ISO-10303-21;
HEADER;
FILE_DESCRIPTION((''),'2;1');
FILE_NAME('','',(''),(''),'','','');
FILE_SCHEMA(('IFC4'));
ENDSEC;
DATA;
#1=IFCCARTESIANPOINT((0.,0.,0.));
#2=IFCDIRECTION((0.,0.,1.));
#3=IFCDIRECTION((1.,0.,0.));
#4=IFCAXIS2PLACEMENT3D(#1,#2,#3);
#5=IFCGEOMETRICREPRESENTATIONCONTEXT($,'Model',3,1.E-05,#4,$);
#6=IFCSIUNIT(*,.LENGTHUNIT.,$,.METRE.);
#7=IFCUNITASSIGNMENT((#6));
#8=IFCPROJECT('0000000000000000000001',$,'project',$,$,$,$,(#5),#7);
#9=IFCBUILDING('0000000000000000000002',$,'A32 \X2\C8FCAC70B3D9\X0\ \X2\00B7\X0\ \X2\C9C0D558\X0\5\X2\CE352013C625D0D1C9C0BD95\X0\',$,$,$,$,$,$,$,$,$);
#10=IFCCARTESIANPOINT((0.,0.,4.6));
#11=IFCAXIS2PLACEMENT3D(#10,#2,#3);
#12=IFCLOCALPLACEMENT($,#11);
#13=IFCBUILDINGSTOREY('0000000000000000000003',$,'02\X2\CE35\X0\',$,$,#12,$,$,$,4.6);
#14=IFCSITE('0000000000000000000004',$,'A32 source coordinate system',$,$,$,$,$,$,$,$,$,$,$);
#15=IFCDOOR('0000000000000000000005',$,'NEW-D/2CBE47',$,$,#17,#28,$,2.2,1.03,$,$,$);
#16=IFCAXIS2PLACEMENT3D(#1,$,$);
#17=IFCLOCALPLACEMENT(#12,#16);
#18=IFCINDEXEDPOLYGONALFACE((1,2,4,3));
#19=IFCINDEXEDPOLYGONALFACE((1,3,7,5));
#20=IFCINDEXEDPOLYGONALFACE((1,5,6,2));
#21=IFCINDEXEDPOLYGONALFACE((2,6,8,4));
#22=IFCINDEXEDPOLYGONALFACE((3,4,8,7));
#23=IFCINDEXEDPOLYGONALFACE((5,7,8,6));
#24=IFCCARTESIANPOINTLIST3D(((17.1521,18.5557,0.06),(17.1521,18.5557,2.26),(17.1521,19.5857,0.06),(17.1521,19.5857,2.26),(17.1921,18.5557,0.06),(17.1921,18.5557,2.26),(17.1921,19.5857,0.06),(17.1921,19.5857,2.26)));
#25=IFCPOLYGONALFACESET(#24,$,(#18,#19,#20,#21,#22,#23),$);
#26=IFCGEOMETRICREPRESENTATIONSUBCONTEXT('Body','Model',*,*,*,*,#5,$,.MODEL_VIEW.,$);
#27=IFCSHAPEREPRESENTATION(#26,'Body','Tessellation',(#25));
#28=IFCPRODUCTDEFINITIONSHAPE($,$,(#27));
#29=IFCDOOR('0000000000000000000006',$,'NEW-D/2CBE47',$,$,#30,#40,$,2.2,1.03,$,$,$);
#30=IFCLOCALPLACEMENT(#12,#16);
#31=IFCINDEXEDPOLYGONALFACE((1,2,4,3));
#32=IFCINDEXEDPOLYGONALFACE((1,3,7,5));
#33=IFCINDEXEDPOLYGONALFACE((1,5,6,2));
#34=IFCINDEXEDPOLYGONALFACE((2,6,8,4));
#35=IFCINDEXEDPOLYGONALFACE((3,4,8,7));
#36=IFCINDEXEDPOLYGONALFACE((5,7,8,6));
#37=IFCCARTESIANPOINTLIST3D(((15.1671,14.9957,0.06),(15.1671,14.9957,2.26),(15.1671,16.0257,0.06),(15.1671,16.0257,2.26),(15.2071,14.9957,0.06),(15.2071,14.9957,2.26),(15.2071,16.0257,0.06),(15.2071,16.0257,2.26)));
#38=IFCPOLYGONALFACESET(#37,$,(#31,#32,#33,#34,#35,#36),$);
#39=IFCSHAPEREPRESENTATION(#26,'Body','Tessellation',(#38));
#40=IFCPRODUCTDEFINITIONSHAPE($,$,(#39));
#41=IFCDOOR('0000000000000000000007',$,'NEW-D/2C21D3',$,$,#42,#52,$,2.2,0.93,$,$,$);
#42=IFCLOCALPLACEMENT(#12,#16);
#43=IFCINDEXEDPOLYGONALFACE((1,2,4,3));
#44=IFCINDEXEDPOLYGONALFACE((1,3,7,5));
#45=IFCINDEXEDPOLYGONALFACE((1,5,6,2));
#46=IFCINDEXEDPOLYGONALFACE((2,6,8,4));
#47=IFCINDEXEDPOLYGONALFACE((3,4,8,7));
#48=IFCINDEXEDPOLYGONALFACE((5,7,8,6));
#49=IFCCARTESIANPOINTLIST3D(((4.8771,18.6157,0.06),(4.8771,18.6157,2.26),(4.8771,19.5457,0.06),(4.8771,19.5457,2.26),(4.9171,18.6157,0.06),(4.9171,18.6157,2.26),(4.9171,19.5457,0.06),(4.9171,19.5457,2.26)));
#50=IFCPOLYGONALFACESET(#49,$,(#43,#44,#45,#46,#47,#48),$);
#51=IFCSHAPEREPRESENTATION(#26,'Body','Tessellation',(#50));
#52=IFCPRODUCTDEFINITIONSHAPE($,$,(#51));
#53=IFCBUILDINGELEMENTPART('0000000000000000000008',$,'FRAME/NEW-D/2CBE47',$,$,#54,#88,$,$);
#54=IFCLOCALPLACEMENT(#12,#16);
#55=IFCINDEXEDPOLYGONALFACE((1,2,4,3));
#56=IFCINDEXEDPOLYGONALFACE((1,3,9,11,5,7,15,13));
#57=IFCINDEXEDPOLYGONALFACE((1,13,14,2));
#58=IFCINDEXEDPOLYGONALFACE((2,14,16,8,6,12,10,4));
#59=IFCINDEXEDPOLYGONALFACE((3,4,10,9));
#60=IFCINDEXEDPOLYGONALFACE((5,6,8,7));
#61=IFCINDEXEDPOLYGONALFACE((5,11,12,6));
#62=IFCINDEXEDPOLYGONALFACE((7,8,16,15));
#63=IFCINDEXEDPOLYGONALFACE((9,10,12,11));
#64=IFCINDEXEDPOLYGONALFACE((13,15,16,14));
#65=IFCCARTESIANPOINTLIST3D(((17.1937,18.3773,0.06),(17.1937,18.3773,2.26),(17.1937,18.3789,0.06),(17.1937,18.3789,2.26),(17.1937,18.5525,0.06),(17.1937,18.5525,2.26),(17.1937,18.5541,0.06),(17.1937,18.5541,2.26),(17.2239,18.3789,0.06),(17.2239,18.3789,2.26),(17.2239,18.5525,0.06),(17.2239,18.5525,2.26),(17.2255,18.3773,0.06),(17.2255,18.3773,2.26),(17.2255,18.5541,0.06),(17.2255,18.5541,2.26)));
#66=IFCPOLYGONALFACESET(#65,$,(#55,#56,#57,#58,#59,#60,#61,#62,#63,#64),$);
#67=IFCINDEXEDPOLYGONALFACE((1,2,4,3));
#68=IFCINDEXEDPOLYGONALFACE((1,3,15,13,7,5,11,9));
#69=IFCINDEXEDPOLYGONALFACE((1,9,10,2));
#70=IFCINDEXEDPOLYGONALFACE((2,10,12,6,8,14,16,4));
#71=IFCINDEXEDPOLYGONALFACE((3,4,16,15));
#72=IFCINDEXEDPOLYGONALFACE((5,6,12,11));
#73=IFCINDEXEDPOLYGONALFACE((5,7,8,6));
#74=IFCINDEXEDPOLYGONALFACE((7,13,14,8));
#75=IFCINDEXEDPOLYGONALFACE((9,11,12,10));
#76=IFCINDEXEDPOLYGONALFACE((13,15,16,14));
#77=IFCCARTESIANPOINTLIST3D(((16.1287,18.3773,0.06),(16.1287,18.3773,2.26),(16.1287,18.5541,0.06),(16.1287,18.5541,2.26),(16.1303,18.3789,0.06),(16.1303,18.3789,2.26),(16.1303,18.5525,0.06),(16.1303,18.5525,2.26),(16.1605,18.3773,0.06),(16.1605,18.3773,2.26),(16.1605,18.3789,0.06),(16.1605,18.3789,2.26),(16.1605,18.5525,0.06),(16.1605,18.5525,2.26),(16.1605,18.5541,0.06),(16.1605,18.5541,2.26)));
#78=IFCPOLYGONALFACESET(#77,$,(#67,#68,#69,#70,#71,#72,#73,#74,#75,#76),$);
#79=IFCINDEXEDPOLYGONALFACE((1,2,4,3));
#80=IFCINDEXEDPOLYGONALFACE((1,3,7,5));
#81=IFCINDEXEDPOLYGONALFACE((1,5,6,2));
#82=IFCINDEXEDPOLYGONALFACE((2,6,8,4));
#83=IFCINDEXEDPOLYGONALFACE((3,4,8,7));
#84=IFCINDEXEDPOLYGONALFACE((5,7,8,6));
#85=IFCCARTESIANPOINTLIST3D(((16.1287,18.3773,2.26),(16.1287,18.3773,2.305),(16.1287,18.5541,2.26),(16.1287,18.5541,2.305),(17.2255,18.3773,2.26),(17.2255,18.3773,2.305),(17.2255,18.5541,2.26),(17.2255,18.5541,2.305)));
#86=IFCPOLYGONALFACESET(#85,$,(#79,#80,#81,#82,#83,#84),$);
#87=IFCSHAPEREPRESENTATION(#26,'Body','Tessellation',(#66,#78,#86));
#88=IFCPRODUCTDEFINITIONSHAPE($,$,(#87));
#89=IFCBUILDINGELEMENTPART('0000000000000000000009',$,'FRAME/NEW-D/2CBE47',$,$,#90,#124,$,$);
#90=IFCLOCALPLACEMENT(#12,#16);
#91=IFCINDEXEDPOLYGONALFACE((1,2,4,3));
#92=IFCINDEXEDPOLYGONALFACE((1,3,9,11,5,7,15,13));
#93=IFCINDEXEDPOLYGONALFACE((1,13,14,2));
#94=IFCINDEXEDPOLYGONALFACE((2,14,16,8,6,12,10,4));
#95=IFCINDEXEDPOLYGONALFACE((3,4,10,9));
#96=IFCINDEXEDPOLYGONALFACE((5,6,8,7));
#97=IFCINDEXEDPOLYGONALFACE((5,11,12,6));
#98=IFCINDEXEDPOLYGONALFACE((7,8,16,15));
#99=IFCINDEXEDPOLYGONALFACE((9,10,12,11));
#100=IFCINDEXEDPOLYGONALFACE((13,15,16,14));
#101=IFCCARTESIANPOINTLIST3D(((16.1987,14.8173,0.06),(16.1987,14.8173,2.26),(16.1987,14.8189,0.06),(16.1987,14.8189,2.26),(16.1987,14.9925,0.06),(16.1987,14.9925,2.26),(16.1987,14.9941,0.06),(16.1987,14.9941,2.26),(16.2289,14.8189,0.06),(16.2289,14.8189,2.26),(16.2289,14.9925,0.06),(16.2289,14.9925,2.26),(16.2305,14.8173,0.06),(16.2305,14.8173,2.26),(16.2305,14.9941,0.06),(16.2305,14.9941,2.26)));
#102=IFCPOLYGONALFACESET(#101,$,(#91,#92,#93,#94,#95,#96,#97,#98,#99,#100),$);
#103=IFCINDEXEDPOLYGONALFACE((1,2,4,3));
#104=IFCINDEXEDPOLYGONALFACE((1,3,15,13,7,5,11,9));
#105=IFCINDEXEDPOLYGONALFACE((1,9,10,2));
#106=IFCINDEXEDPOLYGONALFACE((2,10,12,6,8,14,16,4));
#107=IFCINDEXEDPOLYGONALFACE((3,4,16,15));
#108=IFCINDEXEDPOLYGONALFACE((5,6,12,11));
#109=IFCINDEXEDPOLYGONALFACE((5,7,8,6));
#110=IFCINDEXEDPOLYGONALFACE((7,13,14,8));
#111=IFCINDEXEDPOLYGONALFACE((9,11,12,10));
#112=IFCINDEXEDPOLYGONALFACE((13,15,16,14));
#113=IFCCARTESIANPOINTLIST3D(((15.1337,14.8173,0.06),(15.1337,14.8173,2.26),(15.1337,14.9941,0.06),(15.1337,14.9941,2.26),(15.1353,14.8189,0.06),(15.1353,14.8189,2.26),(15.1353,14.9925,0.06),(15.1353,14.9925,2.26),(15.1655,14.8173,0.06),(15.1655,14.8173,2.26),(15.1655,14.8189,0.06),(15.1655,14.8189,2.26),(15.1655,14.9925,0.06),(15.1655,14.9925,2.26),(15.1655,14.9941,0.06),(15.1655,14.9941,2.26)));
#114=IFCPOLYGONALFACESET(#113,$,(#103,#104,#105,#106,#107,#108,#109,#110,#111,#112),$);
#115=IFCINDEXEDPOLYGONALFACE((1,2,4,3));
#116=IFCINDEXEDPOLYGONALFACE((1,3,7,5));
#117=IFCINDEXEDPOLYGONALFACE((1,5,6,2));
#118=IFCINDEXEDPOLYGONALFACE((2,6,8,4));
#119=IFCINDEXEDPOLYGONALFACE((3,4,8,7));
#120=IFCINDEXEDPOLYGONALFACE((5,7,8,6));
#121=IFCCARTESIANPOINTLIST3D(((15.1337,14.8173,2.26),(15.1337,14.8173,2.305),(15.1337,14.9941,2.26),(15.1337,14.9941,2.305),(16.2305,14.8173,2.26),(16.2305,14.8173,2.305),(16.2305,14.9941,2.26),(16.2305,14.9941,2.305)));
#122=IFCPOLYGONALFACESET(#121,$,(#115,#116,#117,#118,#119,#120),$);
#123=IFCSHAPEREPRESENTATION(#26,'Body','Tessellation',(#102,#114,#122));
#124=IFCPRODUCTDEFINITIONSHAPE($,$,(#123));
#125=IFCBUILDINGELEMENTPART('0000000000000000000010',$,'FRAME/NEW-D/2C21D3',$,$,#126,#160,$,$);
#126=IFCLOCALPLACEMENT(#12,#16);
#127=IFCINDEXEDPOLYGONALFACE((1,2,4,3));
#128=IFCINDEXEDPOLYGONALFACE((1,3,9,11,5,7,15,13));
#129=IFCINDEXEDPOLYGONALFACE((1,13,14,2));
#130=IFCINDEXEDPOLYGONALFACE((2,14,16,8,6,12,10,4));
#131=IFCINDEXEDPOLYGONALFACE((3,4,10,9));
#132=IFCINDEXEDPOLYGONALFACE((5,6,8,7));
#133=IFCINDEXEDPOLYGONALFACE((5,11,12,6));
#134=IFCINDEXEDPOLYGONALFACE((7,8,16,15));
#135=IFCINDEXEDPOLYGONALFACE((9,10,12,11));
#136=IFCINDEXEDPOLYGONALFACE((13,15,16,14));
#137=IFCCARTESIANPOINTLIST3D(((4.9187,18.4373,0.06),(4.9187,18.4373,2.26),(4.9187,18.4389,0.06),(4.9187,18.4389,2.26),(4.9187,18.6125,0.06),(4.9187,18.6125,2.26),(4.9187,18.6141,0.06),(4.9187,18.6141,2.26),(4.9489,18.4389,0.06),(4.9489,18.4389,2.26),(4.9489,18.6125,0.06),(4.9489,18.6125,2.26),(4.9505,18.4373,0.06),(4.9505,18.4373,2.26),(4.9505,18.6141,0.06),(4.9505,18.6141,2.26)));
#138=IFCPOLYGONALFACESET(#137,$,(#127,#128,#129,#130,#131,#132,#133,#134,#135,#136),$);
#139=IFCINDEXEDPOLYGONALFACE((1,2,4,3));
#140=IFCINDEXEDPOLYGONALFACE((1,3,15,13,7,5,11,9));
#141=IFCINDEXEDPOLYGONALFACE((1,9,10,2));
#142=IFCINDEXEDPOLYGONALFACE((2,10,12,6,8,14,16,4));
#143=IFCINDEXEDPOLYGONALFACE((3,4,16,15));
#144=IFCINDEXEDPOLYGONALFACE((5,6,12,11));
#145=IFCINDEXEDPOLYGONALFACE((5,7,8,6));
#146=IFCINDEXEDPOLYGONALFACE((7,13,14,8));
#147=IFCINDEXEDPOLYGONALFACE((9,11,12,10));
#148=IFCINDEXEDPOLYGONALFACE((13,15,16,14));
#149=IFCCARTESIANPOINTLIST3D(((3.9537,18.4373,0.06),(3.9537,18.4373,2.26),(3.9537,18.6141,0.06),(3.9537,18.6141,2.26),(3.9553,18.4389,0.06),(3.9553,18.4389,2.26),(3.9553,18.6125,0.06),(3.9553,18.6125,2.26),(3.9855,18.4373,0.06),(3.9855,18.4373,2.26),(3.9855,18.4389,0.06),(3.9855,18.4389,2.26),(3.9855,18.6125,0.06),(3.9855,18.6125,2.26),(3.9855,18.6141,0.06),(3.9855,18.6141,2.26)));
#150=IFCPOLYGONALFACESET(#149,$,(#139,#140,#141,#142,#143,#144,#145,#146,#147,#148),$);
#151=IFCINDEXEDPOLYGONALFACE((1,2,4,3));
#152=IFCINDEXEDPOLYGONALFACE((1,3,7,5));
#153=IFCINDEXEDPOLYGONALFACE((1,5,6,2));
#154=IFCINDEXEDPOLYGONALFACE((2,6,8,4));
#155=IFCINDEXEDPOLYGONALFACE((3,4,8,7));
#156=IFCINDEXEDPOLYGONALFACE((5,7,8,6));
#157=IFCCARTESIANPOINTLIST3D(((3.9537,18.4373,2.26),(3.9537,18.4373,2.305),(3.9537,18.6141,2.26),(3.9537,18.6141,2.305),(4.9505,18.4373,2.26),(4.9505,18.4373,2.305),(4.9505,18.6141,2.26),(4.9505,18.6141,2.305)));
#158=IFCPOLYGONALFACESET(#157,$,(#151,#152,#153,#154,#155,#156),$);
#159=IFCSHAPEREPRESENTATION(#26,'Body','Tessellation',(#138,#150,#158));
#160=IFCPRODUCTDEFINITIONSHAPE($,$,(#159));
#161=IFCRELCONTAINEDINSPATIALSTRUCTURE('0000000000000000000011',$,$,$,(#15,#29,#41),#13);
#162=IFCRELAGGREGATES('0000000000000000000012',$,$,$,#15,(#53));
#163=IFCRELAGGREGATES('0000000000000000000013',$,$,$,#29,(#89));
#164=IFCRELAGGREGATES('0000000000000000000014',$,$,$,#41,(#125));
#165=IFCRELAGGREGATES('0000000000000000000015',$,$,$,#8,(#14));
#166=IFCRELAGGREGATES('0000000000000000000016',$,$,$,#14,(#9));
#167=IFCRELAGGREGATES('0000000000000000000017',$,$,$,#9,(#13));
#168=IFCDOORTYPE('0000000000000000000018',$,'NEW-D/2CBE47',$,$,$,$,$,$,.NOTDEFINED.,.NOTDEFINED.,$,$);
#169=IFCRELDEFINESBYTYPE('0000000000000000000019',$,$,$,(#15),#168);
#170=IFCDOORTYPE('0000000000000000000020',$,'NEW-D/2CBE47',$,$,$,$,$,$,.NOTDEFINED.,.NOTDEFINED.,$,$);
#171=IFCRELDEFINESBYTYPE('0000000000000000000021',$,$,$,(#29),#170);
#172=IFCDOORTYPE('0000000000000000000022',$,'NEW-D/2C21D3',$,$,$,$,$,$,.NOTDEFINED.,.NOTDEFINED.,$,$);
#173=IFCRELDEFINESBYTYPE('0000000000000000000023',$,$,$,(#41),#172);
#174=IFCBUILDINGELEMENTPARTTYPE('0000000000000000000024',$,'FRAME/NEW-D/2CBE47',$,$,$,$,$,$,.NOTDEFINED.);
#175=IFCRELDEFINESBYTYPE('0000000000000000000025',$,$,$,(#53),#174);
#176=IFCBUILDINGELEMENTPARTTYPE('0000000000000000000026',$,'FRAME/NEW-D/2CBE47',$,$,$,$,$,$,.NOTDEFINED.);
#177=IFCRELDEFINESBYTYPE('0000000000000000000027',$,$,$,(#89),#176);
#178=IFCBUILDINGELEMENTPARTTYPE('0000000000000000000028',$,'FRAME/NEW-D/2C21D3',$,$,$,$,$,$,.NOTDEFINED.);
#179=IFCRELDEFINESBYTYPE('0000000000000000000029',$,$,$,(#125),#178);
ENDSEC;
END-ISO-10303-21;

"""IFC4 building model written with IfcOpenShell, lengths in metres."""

from ifc_helpers import new_model, si_unit, frame, origin, origin_with_axes, place, context, subcontext, project, spatial, polyline, outline, extrude, source, transform, mapped, type_object, type_shapes, element, aggregate, save


model = new_model("IFC4")

# Units and contexts
model_context = context("Model", 3, precision=1e-05, world=origin_with_axes())
body_context = subcontext(model_context, "Body", "Model", "MODEL_VIEW")
ifc_project = project(units=[si_unit("LENGTHUNIT", "METRE")], contexts=[model_context])

# Site, building, storey
site = spatial("IfcSite", under=ifc_project, Name="A32 source coordinate system")
building = spatial("IfcBuilding", under=site, Name="A32 주거동 · 지하5층–옥탑지붕")
storey_placement = place(None, frame((0.0, 0.0, 4.6), z_axis=(0.0, 0.0, 1.0), x_axis=(1.0, 0.0, 0.0)))
storey = spatial("IfcBuildingStorey", under=building, at=storey_placement, Name="02층", Elevation=4.6)

# Doors
door_type_1 = type_object("IfcDoorType", Name="NEW-D/2CBE47", OperationType="NOTDEFINED", PredefinedType="NOTDEFINED")
shared_shape_1 = source(origin(), body_context, "Body", "SweptSolid", [
    extrude(outline(polyline([(17.1921, 18.5557), (17.1521, 18.5557), (17.1521, 19.5857), (17.1921, 19.5857), (17.1921, 18.5557)])), frame((0.0, 0.0, 0.06)), (0.0, 0.0, 1.0), 2.2),
])
type_shapes(door_type_1, [shared_shape_1])
door_1_placement = place(storey_placement, origin_with_axes())
door_1 = element("IfcDoor", 1, at=door_1_placement, inside=storey, type_object=door_type_1, Name="NEW-D/2CBE47", OverallHeight=2.2, OverallWidth=1.03, context=body_context, shape_type="MappedRepresentation", body=[
    mapped(shared_shape_1, transform((0.0, 0.0, 0.0), scale=1.0)),
])
door_type_2 = type_object("IfcDoorType", Name="NEW-D/2CBE47", OperationType="NOTDEFINED", PredefinedType="NOTDEFINED")
shared_shape_2 = source(origin(), body_context, "Body", "SweptSolid", [
    extrude(outline(polyline([(15.2071, 16.0257), (15.2071, 14.9957), (15.1671, 14.9957), (15.1671, 16.0257), (15.2071, 16.0257)])), frame((0.0, 0.0, 0.06)), (0.0, 0.0, 1.0), 2.2),
])
type_shapes(door_type_2, [shared_shape_2])
door_2_placement = place(storey_placement, origin_with_axes())
door_2 = element("IfcDoor", 2, at=door_2_placement, inside=storey, type_object=door_type_2, Name="NEW-D/2CBE47", OverallHeight=2.2, OverallWidth=1.03, context=body_context, shape_type="MappedRepresentation", body=[
    mapped(shared_shape_2, transform((0.0, 0.0, 0.0), scale=1.0)),
])
door_type_3 = type_object("IfcDoorType", Name="NEW-D/2C21D3", OperationType="NOTDEFINED", PredefinedType="NOTDEFINED")
shared_shape_3 = source(origin(), body_context, "Body", "SweptSolid", [
    extrude(outline(polyline([(4.9171, 18.6157), (4.8771, 18.6157), (4.8771, 19.5457), (4.9171, 19.5457), (4.9171, 18.6157)])), frame((0.0, 0.0, 0.06)), (0.0, 0.0, 1.0), 2.2),
])
type_shapes(door_type_3, [shared_shape_3])
door_3_placement = place(storey_placement, origin_with_axes())
door_3 = element("IfcDoor", 3, at=door_3_placement, inside=storey, type_object=door_type_3, Name="NEW-D/2C21D3", OverallHeight=2.2, OverallWidth=0.93, context=body_context, shape_type="MappedRepresentation", body=[
    mapped(shared_shape_3, transform((0.0, 0.0, 0.0), scale=1.0)),
])

# Building element parts
building_element_part_type_1 = type_object("IfcBuildingElementPartType", Name="FRAME/NEW-D/2CBE47", PredefinedType="NOTDEFINED")
shared_shape_4 = source(origin(), body_context, "Body", "SweptSolid", [
    extrude(outline(polyline([(17.2255, 18.3773), (17.1937, 18.3773), (17.1937, 18.3789), (17.2239, 18.3789), (17.2239, 18.5525), (17.1937, 18.5525), (17.1937, 18.5541), (17.2255, 18.5541), (17.2255, 18.3773)])), frame((0.0, 0.0, 0.06)), (0.0, 0.0, 1.0), 2.2),
    extrude(outline(polyline([(16.1303, 18.5525), (16.1303, 18.3789), (16.1605, 18.3789), (16.1605, 18.3773), (16.1287, 18.3773), (16.1287, 18.5541), (16.1605, 18.5541), (16.1605, 18.5525), (16.1303, 18.5525)])), frame((0.0, 0.0, 0.06)), (0.0, 0.0, 1.0), 2.2),
    extrude(outline(polyline([(17.2255, 18.3773), (17.2255, 18.5541), (16.1287, 18.5541), (16.1287, 18.3773), (17.2255, 18.3773)])), frame((0.0, 0.0, 2.26)), (0.0, 0.0, 1.0), 0.045),
])
type_shapes(building_element_part_type_1, [shared_shape_4])
building_element_part_1_placement = place(door_1_placement, origin_with_axes())
building_element_part_1 = element("IfcBuildingElementPart", 4, at=building_element_part_1_placement, type_object=building_element_part_type_1, Name="FRAME/NEW-D/2CBE47", context=body_context, shape_type="MappedRepresentation", body=[
    mapped(shared_shape_4, transform((0.0, 0.0, 0.0), scale=1.0)),
])
aggregate(door_1, [building_element_part_1])
building_element_part_type_2 = type_object("IfcBuildingElementPartType", Name="FRAME/NEW-D/2CBE47", PredefinedType="NOTDEFINED")
shared_shape_5 = source(origin(), body_context, "Body", "SweptSolid", [
    extrude(outline(polyline([(16.2305, 14.8173), (16.1987, 14.8173), (16.1987, 14.8189), (16.2289, 14.8189), (16.2289, 14.9925), (16.1987, 14.9925), (16.1987, 14.9941), (16.2305, 14.9941), (16.2305, 14.8173)])), frame((0.0, 0.0, 0.06)), (0.0, 0.0, 1.0), 2.2),
    extrude(outline(polyline([(15.1353, 14.9925), (15.1353, 14.8189), (15.1655, 14.8189), (15.1655, 14.8173), (15.1337, 14.8173), (15.1337, 14.9941), (15.1655, 14.9941), (15.1655, 14.9925), (15.1353, 14.9925)])), frame((0.0, 0.0, 0.06)), (0.0, 0.0, 1.0), 2.2),
    extrude(outline(polyline([(16.2305, 14.8173), (16.2305, 14.9941), (15.1337, 14.9941), (15.1337, 14.8173), (16.2305, 14.8173)])), frame((0.0, 0.0, 2.26)), (0.0, 0.0, 1.0), 0.045),
])
type_shapes(building_element_part_type_2, [shared_shape_5])
building_element_part_2_placement = place(door_2_placement, origin_with_axes())
building_element_part_2 = element("IfcBuildingElementPart", 5, at=building_element_part_2_placement, type_object=building_element_part_type_2, Name="FRAME/NEW-D/2CBE47", context=body_context, shape_type="MappedRepresentation", body=[
    mapped(shared_shape_5, transform((0.0, 0.0, 0.0), scale=1.0)),
])
aggregate(door_2, [building_element_part_2])
building_element_part_type_3 = type_object("IfcBuildingElementPartType", Name="FRAME/NEW-D/2C21D3", PredefinedType="NOTDEFINED")
shared_shape_6 = source(origin(), body_context, "Body", "SweptSolid", [
    extrude(outline(polyline([(4.9505, 18.4373), (4.9187, 18.4373), (4.9187, 18.4389), (4.9489, 18.4389), (4.9489, 18.6125), (4.9187, 18.6125), (4.9187, 18.6141), (4.9505, 18.6141), (4.9505, 18.4373)])), frame((0.0, 0.0, 0.06)), (0.0, 0.0, 1.0), 2.2),
    extrude(outline(polyline([(3.9553, 18.6125), (3.9553, 18.4389), (3.9855, 18.4389), (3.9855, 18.4373), (3.9537, 18.4373), (3.9537, 18.6141), (3.9855, 18.6141), (3.9855, 18.6125), (3.9553, 18.6125)])), frame((0.0, 0.0, 0.06)), (0.0, 0.0, 1.0), 2.2),
    extrude(outline(polyline([(4.9505, 18.4373), (4.9505, 18.6141), (3.9537, 18.6141), (3.9537, 18.4373), (4.9505, 18.4373)])), frame((0.0, 0.0, 2.26)), (0.0, 0.0, 1.0), 0.045),
])
type_shapes(building_element_part_type_3, [shared_shape_6])
building_element_part_3_placement = place(door_3_placement, origin_with_axes())
building_element_part_3 = element("IfcBuildingElementPart", 6, at=building_element_part_3_placement, type_object=building_element_part_type_3, Name="FRAME/NEW-D/2C21D3", context=body_context, shape_type="MappedRepresentation", body=[
    mapped(shared_shape_6, transform((0.0, 0.0, 0.0), scale=1.0)),
])
aggregate(door_3, [building_element_part_3])

save(model, "model.ifc")
